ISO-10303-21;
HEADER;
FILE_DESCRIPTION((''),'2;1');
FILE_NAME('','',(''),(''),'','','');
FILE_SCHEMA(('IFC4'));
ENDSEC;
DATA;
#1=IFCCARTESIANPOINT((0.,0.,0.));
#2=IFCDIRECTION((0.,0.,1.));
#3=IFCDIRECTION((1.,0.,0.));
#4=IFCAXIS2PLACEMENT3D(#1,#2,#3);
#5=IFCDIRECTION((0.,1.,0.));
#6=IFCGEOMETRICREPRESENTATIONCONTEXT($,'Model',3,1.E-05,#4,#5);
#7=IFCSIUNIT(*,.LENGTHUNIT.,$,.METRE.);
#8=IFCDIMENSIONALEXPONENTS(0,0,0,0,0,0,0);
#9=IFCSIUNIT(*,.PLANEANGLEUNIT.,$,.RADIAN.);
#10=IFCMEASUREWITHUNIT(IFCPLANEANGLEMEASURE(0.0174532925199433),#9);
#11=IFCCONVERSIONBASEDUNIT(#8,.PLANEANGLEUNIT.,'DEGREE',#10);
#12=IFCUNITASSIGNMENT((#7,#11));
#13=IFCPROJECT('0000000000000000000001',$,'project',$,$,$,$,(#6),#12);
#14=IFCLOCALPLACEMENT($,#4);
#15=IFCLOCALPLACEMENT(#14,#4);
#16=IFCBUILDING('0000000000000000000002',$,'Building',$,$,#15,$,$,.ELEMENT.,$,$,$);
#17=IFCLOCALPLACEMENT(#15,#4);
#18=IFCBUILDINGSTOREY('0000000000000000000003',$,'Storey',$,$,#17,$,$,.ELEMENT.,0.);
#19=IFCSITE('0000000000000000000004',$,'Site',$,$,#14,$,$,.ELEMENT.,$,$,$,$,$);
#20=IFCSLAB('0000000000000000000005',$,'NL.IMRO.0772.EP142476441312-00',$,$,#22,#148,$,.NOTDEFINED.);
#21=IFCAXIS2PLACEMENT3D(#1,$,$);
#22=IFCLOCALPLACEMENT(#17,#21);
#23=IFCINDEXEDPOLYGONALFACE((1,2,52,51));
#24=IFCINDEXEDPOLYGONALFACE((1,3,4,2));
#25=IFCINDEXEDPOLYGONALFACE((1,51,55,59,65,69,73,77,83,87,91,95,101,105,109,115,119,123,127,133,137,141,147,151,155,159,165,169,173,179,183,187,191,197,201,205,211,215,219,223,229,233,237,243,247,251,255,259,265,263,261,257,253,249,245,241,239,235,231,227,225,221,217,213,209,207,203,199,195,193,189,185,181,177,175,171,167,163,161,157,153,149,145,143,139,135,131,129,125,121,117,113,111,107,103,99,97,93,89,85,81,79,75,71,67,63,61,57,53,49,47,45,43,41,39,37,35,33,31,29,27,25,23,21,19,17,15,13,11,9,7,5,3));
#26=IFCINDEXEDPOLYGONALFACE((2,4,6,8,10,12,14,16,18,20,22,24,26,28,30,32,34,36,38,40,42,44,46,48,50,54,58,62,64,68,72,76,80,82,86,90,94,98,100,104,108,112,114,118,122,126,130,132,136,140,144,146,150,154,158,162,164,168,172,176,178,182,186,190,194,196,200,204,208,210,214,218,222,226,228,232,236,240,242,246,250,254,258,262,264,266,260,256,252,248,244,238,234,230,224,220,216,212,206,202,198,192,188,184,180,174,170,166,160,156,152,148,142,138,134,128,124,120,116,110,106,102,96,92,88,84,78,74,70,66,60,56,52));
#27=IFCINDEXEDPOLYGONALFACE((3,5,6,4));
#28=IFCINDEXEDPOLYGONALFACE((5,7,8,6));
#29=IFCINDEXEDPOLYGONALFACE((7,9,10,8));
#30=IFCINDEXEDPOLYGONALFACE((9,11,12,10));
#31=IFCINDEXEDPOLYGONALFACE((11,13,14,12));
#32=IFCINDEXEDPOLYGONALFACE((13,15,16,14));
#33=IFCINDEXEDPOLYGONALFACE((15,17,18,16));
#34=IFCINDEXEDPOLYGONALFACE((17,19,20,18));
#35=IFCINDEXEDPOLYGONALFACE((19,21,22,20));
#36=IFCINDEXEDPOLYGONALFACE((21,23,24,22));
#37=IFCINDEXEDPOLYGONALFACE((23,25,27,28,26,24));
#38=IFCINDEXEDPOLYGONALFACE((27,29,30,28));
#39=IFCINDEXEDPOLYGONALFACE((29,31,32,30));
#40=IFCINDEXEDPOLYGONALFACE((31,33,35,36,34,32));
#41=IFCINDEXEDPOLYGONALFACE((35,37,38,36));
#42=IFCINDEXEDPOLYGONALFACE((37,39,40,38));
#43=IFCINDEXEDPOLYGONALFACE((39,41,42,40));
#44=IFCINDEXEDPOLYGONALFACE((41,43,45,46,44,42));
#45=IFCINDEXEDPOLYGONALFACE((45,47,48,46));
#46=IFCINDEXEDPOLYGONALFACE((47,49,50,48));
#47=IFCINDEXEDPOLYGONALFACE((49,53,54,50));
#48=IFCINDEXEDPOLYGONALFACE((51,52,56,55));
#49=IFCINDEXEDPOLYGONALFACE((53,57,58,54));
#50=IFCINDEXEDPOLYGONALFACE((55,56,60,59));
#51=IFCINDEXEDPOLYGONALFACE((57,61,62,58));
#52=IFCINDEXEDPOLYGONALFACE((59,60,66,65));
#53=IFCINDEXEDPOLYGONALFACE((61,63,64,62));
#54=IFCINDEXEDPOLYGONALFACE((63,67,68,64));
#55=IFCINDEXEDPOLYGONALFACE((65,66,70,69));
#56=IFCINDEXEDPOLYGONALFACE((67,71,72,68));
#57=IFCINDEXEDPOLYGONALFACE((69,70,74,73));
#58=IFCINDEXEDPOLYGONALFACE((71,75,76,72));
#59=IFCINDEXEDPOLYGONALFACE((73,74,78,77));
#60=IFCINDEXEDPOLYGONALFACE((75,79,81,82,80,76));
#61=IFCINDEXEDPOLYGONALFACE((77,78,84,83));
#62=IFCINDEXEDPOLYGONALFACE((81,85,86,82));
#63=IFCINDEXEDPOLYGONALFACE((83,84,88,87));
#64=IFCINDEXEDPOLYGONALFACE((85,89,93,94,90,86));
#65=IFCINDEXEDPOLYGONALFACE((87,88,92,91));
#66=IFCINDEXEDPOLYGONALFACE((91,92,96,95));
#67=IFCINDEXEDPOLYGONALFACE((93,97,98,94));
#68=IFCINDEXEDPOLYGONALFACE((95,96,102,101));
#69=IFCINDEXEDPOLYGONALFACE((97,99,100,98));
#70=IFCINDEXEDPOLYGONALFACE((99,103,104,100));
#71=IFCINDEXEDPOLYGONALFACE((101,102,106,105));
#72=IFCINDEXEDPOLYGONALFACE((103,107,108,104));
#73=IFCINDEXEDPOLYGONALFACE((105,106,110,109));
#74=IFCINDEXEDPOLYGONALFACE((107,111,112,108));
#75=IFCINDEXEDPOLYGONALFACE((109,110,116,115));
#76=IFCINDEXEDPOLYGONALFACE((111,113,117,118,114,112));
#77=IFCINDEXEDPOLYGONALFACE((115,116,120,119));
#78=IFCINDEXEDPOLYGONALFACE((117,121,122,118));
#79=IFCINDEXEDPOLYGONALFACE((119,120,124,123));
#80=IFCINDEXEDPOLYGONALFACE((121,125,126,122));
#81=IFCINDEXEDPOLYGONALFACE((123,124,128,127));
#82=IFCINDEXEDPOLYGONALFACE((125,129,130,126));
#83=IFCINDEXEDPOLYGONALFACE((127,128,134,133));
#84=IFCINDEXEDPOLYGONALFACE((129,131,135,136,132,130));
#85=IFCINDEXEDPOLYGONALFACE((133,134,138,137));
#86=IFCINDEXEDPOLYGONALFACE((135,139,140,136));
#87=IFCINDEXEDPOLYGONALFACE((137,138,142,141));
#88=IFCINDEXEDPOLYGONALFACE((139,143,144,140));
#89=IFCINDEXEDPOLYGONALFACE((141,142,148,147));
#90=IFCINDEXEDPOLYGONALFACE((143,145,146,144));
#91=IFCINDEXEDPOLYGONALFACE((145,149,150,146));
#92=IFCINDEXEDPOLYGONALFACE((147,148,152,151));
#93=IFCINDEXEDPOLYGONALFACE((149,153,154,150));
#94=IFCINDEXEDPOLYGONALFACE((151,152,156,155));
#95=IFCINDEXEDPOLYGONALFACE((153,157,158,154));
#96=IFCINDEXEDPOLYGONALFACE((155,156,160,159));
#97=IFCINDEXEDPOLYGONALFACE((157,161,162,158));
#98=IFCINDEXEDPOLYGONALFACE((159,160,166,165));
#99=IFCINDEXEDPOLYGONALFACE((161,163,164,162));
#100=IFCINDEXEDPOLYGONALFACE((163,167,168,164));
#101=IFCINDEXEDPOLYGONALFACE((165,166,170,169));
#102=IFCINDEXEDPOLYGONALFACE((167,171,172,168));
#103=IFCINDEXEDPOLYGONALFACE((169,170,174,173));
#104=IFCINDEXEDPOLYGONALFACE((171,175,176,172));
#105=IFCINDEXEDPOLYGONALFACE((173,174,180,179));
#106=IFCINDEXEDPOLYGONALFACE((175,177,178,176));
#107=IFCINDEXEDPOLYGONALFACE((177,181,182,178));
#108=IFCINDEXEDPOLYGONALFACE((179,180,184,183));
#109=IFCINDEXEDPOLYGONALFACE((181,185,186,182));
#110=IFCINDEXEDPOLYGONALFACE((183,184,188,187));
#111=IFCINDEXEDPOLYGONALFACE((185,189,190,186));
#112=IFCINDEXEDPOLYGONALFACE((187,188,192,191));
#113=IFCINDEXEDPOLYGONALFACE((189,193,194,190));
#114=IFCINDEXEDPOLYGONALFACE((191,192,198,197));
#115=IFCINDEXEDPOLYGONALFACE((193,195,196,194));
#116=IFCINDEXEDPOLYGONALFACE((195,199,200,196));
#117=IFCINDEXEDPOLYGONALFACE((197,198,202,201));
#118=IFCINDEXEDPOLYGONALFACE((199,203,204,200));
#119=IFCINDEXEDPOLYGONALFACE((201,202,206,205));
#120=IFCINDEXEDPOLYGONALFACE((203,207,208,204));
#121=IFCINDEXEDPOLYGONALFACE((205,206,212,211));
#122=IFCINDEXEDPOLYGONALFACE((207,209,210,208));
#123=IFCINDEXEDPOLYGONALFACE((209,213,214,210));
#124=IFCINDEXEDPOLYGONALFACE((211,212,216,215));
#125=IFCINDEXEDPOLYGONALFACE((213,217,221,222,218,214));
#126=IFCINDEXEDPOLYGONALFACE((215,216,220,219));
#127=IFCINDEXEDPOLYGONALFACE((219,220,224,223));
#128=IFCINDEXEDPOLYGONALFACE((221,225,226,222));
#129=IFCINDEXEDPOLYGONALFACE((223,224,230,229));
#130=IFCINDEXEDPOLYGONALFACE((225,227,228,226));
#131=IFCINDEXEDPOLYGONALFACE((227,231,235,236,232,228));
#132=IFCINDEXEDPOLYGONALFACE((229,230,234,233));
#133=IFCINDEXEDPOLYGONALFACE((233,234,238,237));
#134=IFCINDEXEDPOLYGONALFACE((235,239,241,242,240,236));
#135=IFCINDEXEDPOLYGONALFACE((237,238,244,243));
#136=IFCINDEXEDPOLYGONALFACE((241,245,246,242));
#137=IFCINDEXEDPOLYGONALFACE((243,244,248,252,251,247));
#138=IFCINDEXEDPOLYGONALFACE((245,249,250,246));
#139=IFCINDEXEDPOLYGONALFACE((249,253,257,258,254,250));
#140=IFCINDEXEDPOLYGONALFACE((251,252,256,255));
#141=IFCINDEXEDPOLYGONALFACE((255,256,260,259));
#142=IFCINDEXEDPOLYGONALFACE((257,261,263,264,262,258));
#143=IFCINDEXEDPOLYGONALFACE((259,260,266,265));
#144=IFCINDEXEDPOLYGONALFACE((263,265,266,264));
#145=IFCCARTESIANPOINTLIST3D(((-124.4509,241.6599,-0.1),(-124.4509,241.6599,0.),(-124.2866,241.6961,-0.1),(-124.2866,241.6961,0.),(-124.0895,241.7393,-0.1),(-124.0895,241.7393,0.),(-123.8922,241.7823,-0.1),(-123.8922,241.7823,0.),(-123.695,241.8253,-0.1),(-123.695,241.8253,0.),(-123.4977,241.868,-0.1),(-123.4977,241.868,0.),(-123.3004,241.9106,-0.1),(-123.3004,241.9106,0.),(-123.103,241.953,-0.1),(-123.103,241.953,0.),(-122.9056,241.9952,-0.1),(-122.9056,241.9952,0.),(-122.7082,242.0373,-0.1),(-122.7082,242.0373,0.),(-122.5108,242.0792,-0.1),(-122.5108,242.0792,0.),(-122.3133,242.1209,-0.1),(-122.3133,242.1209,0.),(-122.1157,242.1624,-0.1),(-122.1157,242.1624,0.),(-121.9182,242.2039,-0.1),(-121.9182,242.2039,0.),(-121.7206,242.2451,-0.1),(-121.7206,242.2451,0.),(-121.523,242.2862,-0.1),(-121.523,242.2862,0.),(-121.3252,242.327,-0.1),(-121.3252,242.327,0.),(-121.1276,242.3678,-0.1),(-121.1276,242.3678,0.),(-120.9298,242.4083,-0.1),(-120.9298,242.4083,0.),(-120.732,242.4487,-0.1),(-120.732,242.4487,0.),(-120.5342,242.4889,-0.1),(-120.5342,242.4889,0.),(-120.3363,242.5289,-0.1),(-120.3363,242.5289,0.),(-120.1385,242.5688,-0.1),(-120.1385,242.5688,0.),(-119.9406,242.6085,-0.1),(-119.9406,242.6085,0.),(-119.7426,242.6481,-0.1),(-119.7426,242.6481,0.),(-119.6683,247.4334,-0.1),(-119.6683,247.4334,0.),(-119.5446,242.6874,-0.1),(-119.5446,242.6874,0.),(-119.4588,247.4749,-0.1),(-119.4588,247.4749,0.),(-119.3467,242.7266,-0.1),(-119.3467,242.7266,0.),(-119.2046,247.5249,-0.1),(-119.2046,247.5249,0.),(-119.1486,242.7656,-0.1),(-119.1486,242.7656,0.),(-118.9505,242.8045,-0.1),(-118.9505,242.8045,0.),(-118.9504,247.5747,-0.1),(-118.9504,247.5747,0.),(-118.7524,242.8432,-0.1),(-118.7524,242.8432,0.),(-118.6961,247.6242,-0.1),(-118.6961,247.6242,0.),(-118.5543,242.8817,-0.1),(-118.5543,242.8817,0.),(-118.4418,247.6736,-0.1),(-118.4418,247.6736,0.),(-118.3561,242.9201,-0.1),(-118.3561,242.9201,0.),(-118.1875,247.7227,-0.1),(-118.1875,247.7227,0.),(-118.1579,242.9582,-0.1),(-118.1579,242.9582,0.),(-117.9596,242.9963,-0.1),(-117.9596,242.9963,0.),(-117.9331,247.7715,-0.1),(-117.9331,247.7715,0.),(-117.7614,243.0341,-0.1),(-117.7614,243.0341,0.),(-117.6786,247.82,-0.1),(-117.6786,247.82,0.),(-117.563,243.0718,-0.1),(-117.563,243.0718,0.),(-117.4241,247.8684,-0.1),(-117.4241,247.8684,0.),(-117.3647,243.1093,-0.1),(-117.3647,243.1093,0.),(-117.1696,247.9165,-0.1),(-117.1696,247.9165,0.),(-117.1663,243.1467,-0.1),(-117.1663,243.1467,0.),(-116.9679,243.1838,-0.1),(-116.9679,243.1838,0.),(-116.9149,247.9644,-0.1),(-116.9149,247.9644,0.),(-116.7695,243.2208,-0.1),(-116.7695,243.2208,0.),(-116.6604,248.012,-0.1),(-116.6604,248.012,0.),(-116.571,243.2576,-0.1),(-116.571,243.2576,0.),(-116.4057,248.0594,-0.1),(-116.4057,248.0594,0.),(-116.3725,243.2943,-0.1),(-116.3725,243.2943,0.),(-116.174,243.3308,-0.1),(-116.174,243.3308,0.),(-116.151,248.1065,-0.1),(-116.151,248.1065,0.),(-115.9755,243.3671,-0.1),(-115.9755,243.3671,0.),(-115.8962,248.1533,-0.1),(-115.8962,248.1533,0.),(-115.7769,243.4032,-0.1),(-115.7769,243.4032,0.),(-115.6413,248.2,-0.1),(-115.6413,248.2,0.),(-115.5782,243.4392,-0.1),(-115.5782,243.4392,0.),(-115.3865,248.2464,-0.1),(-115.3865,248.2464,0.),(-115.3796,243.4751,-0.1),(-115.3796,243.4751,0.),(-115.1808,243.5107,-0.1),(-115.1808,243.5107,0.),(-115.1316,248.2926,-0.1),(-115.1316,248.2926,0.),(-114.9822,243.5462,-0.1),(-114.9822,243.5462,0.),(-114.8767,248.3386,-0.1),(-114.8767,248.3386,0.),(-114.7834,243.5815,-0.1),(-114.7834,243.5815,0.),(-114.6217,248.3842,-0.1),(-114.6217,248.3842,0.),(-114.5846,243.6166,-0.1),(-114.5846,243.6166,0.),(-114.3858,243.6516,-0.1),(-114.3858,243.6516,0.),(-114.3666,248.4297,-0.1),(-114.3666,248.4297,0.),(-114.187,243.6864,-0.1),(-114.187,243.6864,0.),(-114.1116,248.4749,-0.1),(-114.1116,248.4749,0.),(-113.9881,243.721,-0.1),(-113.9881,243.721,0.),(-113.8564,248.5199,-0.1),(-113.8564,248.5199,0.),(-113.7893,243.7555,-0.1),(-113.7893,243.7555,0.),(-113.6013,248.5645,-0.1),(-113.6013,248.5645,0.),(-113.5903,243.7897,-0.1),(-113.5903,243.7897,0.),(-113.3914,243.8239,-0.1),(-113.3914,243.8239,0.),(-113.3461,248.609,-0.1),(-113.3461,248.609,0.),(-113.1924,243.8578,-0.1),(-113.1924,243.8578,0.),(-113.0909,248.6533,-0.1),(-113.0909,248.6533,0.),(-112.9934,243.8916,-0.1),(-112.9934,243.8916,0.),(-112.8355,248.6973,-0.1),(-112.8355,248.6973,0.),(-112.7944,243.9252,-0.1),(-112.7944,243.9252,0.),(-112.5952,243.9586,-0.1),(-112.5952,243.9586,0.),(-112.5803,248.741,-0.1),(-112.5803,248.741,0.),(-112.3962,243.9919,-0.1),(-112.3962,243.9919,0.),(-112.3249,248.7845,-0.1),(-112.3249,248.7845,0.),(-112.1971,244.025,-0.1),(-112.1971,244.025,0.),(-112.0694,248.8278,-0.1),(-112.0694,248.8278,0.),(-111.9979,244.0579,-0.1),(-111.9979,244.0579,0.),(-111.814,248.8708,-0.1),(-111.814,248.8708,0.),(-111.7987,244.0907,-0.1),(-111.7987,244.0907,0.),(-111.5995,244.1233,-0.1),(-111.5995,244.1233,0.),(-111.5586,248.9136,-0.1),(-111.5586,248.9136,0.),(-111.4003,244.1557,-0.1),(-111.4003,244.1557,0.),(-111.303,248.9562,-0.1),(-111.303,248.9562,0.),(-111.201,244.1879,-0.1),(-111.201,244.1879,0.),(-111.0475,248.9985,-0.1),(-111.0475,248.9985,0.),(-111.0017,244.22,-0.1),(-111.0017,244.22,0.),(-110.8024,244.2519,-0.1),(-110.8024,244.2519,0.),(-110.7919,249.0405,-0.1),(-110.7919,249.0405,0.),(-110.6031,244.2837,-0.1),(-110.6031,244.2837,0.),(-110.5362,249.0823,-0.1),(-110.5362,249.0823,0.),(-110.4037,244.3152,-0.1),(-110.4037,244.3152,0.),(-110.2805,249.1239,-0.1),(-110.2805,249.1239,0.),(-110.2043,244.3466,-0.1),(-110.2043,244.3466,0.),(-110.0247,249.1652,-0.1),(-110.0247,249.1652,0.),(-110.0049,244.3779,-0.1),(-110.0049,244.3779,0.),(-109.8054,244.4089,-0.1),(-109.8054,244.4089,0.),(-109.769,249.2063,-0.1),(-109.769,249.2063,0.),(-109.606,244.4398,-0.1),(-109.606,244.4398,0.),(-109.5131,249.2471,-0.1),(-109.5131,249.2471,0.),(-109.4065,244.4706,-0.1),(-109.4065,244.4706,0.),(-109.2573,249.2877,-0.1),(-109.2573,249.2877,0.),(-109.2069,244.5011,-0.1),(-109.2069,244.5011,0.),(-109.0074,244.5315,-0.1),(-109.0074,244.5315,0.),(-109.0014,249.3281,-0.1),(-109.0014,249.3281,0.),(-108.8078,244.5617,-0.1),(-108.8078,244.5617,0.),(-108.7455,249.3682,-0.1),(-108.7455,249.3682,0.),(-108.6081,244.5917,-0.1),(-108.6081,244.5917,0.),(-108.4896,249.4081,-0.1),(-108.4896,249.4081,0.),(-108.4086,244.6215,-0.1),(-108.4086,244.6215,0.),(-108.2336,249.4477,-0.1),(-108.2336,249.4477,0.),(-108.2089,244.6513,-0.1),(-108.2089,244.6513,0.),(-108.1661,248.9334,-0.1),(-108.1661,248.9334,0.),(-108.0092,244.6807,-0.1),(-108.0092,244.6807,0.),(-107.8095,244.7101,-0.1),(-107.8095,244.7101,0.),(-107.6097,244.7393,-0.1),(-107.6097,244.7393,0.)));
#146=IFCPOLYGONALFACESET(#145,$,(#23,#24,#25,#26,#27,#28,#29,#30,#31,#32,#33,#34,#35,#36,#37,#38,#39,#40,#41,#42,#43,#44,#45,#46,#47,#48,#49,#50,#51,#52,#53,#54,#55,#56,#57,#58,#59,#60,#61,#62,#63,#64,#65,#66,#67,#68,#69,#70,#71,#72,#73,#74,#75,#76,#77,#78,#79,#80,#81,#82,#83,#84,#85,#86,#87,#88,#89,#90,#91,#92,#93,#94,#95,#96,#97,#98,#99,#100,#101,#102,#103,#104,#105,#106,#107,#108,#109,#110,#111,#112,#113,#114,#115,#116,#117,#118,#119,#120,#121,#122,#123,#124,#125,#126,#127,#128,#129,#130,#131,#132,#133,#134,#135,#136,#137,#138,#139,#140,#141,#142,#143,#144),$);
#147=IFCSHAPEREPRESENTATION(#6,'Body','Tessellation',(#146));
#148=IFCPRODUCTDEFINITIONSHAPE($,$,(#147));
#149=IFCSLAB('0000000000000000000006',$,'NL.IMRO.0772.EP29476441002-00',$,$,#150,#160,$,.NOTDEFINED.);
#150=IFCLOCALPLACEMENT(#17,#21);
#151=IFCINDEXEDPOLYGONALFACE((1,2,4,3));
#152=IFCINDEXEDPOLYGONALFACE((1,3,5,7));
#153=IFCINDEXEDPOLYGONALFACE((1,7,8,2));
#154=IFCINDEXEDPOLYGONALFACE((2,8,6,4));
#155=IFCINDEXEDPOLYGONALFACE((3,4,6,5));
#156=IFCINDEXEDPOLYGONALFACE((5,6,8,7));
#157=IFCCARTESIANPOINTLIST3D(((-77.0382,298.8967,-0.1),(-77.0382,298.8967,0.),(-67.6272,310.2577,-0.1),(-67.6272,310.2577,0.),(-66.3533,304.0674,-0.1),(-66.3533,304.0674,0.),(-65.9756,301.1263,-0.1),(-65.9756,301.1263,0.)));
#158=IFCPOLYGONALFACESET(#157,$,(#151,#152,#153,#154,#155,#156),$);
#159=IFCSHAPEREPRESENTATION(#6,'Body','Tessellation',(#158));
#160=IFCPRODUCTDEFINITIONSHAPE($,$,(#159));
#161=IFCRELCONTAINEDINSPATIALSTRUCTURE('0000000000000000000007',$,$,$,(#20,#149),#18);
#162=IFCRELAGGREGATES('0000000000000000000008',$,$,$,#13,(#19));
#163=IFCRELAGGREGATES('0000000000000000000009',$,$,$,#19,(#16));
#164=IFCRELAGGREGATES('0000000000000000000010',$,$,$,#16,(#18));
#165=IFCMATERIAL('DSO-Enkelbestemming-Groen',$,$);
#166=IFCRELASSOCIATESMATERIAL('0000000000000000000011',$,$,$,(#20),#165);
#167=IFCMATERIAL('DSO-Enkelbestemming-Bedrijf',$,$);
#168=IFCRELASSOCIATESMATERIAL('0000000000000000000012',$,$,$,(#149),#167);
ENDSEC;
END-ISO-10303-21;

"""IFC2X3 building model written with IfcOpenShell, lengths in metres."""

from ifc_helpers import new_model, entity, si_unit, converted_unit, direction, frame, origin_with_axes, place, context, project, spatial, polyline, outline, extrude, material, element, save


model = new_model("IFC2X3")

# Units and contexts
model_context = context("Model", 3, precision=1e-05, world=origin_with_axes(), true_north=direction((0.0, 1.0, 0.0)))
ifc_project = project(units=[si_unit("LENGTHUNIT", "METRE"), converted_unit("PLANEANGLEUNIT", "DEGREE", entity("IfcPlaneAngleMeasure", 0.0174532925199433), si_unit("PLANEANGLEUNIT", "RADIAN"), dimensions=[0, 0, 0, 0, 0, 0, 0])], contexts=[model_context])

# Site, building, storey
site_placement = place(None, origin_with_axes())
site = spatial("IfcSite", under=ifc_project, at=site_placement, Name="Site", CompositionType="ELEMENT")
building_placement = place(site_placement, origin_with_axes())
building = spatial("IfcBuilding", under=site, at=building_placement, Name="Building", CompositionType="ELEMENT")
storey_placement = place(building_placement, origin_with_axes())
storey = spatial("IfcBuildingStorey", under=building, at=storey_placement, Name="Storey", CompositionType="ELEMENT", Elevation=0.0)

# Slabs
ifc_material_1 = material(Name="DSO-Enkelbestemming-Groen")
slab_1_placement = place(storey_placement, frame((0.0, 0.0, -0.1), z_axis=(0.0, 0.0, 1.0), x_axis=(1.0, 0.0, 0.0)))
element("IfcSlab", 1, at=slab_1_placement, inside=storey, material=ifc_material_1, Name="NL.IMRO.0772.EP142476441312-00", PredefinedType="NOTDEFINED", context=model_context, shape_type="SweptSolid", body=[
    extrude(outline(polyline([(-119.4588, 247.4749), (-119.2046, 247.5249), (-118.9504, 247.5747), (-118.6961, 247.6242), (-118.4418, 247.6736), (-118.1875, 247.7227), (-117.9331, 247.7715), (-117.6786, 247.82), (-117.4241, 247.8684), (-117.1696, 247.9165), (-116.9149, 247.9644), (-116.6604, 248.012), (-116.4057, 248.0594), (-116.151, 248.1065), (-115.8962, 248.1533), (-115.6413, 248.2), (-115.3865, 248.2464), (-115.1316, 248.2926), (-114.8767, 248.3386), (-114.6217, 248.3842), (-114.3666, 248.4297), (-114.1116, 248.4749), (-113.8564, 248.5199), (-113.6013, 248.5645), (-113.3461, 248.609), (-113.0909, 248.6533), (-112.8355, 248.6973), (-112.5803, 248.741), (-112.3249, 248.7845), (-112.0694, 248.8278), (-111.814, 248.8708), (-111.5586, 248.9136), (-111.303, 248.9562), (-111.0475, 248.9985), (-110.7919, 249.0405), (-110.5362, 249.0823), (-110.2805, 249.1239), (-110.0247, 249.1652), (-109.769, 249.2063), (-109.5131, 249.2471), (-109.2573, 249.2877), (-109.0014, 249.3281), (-108.7455, 249.3682), (-108.4896, 249.4081), (-108.2336, 249.4477), (-108.1661, 248.9334), (-107.6097, 244.7393), (-107.8095, 244.7101), (-108.0092, 244.6807), (-108.2089, 244.6513), (-108.4086, 244.6215), (-108.6081, 244.5917), (-108.8078, 244.5617), (-109.0074, 244.5315), (-109.2069, 244.5011), (-109.4065, 244.4706), (-109.606, 244.4398), (-109.8054, 244.4089), (-110.0049, 244.3779), (-110.2043, 244.3466), (-110.4037, 244.3152), (-110.6031, 244.2837), (-110.8024, 244.2519), (-111.0017, 244.22), (-111.201, 244.1879), (-111.4003, 244.1557), (-111.5995, 244.1233), (-111.7987, 244.0907), (-111.9979, 244.0579), (-112.1971, 244.025), (-112.3962, 243.9919), (-112.5952, 243.9586), (-112.7944, 243.9252), (-112.9934, 243.8916), (-113.1924, 243.8578), (-113.3914, 243.8239), (-113.5903, 243.7897), (-113.7893, 243.7555), (-113.9881, 243.721), (-114.187, 243.6864), (-114.3858, 243.6516), (-114.5846, 243.6166), (-114.7834, 243.5815), (-114.9822, 243.5462), (-115.1808, 243.5107), (-115.3796, 243.4751), (-115.5782, 243.4392), (-115.7769, 243.4032), (-115.9755, 243.3671), (-116.174, 243.3308), (-116.3725, 243.2943), (-116.571, 243.2576), (-116.7695, 243.2208), (-116.9679, 243.1838), (-117.1663, 243.1467), (-117.3647, 243.1093), (-117.563, 243.0718), (-117.7614, 243.0341), (-117.9596, 242.9963), (-118.1579, 242.9582), (-118.3561, 242.9201), (-118.5543, 242.8817), (-118.7524, 242.8432), (-118.9505, 242.8045), (-119.1486, 242.7656), (-119.3467, 242.7266), (-119.5446, 242.6874), (-119.7426, 242.6481), (-119.9406, 242.6085), (-120.1385, 242.5688), (-120.3363, 242.5289), (-120.5342, 242.4889), (-120.732, 242.4487), (-120.9298, 242.4083), (-121.1276, 242.3678), (-121.3252, 242.327), (-121.523, 242.2862), (-121.7206, 242.2451), (-121.9182, 242.2039), (-122.1157, 242.1624), (-122.3133, 242.1209), (-122.5108, 242.0792), (-122.7082, 242.0373), (-122.9056, 241.9952), (-123.103, 241.953), (-123.3004, 241.9106), (-123.4977, 241.868), (-123.695, 241.8253), (-123.8922, 241.7823), (-124.0895, 241.7393), (-124.2866, 241.6961), (-124.4509, 241.6599), (-119.6683, 247.4334), (-119.4588, 247.4749)])), origin_with_axes(), (0.0, 0.0, 1.0), 0.1),
])
ifc_material_2 = material(Name="DSO-Enkelbestemming-Bedrijf")
slab_2_placement = place(storey_placement, frame((0.0, 0.0, -0.1), z_axis=(0.0, 0.0, 1.0), x_axis=(1.0, 0.0, 0.0)))
element("IfcSlab", 2, at=slab_2_placement, inside=storey, material=ifc_material_2, Name="NL.IMRO.0772.EP29476441002-00", PredefinedType="NOTDEFINED", context=model_context, shape_type="SweptSolid", body=[
    extrude(outline(polyline([(-66.3533, 304.0674), (-65.9756, 301.1263), (-77.0382, 298.8967), (-67.6272, 310.2577), (-66.3533, 304.0674)])), origin_with_axes(), (0.0, 0.0, 1.0), 0.1),
])

save(model, "model.ifc")
